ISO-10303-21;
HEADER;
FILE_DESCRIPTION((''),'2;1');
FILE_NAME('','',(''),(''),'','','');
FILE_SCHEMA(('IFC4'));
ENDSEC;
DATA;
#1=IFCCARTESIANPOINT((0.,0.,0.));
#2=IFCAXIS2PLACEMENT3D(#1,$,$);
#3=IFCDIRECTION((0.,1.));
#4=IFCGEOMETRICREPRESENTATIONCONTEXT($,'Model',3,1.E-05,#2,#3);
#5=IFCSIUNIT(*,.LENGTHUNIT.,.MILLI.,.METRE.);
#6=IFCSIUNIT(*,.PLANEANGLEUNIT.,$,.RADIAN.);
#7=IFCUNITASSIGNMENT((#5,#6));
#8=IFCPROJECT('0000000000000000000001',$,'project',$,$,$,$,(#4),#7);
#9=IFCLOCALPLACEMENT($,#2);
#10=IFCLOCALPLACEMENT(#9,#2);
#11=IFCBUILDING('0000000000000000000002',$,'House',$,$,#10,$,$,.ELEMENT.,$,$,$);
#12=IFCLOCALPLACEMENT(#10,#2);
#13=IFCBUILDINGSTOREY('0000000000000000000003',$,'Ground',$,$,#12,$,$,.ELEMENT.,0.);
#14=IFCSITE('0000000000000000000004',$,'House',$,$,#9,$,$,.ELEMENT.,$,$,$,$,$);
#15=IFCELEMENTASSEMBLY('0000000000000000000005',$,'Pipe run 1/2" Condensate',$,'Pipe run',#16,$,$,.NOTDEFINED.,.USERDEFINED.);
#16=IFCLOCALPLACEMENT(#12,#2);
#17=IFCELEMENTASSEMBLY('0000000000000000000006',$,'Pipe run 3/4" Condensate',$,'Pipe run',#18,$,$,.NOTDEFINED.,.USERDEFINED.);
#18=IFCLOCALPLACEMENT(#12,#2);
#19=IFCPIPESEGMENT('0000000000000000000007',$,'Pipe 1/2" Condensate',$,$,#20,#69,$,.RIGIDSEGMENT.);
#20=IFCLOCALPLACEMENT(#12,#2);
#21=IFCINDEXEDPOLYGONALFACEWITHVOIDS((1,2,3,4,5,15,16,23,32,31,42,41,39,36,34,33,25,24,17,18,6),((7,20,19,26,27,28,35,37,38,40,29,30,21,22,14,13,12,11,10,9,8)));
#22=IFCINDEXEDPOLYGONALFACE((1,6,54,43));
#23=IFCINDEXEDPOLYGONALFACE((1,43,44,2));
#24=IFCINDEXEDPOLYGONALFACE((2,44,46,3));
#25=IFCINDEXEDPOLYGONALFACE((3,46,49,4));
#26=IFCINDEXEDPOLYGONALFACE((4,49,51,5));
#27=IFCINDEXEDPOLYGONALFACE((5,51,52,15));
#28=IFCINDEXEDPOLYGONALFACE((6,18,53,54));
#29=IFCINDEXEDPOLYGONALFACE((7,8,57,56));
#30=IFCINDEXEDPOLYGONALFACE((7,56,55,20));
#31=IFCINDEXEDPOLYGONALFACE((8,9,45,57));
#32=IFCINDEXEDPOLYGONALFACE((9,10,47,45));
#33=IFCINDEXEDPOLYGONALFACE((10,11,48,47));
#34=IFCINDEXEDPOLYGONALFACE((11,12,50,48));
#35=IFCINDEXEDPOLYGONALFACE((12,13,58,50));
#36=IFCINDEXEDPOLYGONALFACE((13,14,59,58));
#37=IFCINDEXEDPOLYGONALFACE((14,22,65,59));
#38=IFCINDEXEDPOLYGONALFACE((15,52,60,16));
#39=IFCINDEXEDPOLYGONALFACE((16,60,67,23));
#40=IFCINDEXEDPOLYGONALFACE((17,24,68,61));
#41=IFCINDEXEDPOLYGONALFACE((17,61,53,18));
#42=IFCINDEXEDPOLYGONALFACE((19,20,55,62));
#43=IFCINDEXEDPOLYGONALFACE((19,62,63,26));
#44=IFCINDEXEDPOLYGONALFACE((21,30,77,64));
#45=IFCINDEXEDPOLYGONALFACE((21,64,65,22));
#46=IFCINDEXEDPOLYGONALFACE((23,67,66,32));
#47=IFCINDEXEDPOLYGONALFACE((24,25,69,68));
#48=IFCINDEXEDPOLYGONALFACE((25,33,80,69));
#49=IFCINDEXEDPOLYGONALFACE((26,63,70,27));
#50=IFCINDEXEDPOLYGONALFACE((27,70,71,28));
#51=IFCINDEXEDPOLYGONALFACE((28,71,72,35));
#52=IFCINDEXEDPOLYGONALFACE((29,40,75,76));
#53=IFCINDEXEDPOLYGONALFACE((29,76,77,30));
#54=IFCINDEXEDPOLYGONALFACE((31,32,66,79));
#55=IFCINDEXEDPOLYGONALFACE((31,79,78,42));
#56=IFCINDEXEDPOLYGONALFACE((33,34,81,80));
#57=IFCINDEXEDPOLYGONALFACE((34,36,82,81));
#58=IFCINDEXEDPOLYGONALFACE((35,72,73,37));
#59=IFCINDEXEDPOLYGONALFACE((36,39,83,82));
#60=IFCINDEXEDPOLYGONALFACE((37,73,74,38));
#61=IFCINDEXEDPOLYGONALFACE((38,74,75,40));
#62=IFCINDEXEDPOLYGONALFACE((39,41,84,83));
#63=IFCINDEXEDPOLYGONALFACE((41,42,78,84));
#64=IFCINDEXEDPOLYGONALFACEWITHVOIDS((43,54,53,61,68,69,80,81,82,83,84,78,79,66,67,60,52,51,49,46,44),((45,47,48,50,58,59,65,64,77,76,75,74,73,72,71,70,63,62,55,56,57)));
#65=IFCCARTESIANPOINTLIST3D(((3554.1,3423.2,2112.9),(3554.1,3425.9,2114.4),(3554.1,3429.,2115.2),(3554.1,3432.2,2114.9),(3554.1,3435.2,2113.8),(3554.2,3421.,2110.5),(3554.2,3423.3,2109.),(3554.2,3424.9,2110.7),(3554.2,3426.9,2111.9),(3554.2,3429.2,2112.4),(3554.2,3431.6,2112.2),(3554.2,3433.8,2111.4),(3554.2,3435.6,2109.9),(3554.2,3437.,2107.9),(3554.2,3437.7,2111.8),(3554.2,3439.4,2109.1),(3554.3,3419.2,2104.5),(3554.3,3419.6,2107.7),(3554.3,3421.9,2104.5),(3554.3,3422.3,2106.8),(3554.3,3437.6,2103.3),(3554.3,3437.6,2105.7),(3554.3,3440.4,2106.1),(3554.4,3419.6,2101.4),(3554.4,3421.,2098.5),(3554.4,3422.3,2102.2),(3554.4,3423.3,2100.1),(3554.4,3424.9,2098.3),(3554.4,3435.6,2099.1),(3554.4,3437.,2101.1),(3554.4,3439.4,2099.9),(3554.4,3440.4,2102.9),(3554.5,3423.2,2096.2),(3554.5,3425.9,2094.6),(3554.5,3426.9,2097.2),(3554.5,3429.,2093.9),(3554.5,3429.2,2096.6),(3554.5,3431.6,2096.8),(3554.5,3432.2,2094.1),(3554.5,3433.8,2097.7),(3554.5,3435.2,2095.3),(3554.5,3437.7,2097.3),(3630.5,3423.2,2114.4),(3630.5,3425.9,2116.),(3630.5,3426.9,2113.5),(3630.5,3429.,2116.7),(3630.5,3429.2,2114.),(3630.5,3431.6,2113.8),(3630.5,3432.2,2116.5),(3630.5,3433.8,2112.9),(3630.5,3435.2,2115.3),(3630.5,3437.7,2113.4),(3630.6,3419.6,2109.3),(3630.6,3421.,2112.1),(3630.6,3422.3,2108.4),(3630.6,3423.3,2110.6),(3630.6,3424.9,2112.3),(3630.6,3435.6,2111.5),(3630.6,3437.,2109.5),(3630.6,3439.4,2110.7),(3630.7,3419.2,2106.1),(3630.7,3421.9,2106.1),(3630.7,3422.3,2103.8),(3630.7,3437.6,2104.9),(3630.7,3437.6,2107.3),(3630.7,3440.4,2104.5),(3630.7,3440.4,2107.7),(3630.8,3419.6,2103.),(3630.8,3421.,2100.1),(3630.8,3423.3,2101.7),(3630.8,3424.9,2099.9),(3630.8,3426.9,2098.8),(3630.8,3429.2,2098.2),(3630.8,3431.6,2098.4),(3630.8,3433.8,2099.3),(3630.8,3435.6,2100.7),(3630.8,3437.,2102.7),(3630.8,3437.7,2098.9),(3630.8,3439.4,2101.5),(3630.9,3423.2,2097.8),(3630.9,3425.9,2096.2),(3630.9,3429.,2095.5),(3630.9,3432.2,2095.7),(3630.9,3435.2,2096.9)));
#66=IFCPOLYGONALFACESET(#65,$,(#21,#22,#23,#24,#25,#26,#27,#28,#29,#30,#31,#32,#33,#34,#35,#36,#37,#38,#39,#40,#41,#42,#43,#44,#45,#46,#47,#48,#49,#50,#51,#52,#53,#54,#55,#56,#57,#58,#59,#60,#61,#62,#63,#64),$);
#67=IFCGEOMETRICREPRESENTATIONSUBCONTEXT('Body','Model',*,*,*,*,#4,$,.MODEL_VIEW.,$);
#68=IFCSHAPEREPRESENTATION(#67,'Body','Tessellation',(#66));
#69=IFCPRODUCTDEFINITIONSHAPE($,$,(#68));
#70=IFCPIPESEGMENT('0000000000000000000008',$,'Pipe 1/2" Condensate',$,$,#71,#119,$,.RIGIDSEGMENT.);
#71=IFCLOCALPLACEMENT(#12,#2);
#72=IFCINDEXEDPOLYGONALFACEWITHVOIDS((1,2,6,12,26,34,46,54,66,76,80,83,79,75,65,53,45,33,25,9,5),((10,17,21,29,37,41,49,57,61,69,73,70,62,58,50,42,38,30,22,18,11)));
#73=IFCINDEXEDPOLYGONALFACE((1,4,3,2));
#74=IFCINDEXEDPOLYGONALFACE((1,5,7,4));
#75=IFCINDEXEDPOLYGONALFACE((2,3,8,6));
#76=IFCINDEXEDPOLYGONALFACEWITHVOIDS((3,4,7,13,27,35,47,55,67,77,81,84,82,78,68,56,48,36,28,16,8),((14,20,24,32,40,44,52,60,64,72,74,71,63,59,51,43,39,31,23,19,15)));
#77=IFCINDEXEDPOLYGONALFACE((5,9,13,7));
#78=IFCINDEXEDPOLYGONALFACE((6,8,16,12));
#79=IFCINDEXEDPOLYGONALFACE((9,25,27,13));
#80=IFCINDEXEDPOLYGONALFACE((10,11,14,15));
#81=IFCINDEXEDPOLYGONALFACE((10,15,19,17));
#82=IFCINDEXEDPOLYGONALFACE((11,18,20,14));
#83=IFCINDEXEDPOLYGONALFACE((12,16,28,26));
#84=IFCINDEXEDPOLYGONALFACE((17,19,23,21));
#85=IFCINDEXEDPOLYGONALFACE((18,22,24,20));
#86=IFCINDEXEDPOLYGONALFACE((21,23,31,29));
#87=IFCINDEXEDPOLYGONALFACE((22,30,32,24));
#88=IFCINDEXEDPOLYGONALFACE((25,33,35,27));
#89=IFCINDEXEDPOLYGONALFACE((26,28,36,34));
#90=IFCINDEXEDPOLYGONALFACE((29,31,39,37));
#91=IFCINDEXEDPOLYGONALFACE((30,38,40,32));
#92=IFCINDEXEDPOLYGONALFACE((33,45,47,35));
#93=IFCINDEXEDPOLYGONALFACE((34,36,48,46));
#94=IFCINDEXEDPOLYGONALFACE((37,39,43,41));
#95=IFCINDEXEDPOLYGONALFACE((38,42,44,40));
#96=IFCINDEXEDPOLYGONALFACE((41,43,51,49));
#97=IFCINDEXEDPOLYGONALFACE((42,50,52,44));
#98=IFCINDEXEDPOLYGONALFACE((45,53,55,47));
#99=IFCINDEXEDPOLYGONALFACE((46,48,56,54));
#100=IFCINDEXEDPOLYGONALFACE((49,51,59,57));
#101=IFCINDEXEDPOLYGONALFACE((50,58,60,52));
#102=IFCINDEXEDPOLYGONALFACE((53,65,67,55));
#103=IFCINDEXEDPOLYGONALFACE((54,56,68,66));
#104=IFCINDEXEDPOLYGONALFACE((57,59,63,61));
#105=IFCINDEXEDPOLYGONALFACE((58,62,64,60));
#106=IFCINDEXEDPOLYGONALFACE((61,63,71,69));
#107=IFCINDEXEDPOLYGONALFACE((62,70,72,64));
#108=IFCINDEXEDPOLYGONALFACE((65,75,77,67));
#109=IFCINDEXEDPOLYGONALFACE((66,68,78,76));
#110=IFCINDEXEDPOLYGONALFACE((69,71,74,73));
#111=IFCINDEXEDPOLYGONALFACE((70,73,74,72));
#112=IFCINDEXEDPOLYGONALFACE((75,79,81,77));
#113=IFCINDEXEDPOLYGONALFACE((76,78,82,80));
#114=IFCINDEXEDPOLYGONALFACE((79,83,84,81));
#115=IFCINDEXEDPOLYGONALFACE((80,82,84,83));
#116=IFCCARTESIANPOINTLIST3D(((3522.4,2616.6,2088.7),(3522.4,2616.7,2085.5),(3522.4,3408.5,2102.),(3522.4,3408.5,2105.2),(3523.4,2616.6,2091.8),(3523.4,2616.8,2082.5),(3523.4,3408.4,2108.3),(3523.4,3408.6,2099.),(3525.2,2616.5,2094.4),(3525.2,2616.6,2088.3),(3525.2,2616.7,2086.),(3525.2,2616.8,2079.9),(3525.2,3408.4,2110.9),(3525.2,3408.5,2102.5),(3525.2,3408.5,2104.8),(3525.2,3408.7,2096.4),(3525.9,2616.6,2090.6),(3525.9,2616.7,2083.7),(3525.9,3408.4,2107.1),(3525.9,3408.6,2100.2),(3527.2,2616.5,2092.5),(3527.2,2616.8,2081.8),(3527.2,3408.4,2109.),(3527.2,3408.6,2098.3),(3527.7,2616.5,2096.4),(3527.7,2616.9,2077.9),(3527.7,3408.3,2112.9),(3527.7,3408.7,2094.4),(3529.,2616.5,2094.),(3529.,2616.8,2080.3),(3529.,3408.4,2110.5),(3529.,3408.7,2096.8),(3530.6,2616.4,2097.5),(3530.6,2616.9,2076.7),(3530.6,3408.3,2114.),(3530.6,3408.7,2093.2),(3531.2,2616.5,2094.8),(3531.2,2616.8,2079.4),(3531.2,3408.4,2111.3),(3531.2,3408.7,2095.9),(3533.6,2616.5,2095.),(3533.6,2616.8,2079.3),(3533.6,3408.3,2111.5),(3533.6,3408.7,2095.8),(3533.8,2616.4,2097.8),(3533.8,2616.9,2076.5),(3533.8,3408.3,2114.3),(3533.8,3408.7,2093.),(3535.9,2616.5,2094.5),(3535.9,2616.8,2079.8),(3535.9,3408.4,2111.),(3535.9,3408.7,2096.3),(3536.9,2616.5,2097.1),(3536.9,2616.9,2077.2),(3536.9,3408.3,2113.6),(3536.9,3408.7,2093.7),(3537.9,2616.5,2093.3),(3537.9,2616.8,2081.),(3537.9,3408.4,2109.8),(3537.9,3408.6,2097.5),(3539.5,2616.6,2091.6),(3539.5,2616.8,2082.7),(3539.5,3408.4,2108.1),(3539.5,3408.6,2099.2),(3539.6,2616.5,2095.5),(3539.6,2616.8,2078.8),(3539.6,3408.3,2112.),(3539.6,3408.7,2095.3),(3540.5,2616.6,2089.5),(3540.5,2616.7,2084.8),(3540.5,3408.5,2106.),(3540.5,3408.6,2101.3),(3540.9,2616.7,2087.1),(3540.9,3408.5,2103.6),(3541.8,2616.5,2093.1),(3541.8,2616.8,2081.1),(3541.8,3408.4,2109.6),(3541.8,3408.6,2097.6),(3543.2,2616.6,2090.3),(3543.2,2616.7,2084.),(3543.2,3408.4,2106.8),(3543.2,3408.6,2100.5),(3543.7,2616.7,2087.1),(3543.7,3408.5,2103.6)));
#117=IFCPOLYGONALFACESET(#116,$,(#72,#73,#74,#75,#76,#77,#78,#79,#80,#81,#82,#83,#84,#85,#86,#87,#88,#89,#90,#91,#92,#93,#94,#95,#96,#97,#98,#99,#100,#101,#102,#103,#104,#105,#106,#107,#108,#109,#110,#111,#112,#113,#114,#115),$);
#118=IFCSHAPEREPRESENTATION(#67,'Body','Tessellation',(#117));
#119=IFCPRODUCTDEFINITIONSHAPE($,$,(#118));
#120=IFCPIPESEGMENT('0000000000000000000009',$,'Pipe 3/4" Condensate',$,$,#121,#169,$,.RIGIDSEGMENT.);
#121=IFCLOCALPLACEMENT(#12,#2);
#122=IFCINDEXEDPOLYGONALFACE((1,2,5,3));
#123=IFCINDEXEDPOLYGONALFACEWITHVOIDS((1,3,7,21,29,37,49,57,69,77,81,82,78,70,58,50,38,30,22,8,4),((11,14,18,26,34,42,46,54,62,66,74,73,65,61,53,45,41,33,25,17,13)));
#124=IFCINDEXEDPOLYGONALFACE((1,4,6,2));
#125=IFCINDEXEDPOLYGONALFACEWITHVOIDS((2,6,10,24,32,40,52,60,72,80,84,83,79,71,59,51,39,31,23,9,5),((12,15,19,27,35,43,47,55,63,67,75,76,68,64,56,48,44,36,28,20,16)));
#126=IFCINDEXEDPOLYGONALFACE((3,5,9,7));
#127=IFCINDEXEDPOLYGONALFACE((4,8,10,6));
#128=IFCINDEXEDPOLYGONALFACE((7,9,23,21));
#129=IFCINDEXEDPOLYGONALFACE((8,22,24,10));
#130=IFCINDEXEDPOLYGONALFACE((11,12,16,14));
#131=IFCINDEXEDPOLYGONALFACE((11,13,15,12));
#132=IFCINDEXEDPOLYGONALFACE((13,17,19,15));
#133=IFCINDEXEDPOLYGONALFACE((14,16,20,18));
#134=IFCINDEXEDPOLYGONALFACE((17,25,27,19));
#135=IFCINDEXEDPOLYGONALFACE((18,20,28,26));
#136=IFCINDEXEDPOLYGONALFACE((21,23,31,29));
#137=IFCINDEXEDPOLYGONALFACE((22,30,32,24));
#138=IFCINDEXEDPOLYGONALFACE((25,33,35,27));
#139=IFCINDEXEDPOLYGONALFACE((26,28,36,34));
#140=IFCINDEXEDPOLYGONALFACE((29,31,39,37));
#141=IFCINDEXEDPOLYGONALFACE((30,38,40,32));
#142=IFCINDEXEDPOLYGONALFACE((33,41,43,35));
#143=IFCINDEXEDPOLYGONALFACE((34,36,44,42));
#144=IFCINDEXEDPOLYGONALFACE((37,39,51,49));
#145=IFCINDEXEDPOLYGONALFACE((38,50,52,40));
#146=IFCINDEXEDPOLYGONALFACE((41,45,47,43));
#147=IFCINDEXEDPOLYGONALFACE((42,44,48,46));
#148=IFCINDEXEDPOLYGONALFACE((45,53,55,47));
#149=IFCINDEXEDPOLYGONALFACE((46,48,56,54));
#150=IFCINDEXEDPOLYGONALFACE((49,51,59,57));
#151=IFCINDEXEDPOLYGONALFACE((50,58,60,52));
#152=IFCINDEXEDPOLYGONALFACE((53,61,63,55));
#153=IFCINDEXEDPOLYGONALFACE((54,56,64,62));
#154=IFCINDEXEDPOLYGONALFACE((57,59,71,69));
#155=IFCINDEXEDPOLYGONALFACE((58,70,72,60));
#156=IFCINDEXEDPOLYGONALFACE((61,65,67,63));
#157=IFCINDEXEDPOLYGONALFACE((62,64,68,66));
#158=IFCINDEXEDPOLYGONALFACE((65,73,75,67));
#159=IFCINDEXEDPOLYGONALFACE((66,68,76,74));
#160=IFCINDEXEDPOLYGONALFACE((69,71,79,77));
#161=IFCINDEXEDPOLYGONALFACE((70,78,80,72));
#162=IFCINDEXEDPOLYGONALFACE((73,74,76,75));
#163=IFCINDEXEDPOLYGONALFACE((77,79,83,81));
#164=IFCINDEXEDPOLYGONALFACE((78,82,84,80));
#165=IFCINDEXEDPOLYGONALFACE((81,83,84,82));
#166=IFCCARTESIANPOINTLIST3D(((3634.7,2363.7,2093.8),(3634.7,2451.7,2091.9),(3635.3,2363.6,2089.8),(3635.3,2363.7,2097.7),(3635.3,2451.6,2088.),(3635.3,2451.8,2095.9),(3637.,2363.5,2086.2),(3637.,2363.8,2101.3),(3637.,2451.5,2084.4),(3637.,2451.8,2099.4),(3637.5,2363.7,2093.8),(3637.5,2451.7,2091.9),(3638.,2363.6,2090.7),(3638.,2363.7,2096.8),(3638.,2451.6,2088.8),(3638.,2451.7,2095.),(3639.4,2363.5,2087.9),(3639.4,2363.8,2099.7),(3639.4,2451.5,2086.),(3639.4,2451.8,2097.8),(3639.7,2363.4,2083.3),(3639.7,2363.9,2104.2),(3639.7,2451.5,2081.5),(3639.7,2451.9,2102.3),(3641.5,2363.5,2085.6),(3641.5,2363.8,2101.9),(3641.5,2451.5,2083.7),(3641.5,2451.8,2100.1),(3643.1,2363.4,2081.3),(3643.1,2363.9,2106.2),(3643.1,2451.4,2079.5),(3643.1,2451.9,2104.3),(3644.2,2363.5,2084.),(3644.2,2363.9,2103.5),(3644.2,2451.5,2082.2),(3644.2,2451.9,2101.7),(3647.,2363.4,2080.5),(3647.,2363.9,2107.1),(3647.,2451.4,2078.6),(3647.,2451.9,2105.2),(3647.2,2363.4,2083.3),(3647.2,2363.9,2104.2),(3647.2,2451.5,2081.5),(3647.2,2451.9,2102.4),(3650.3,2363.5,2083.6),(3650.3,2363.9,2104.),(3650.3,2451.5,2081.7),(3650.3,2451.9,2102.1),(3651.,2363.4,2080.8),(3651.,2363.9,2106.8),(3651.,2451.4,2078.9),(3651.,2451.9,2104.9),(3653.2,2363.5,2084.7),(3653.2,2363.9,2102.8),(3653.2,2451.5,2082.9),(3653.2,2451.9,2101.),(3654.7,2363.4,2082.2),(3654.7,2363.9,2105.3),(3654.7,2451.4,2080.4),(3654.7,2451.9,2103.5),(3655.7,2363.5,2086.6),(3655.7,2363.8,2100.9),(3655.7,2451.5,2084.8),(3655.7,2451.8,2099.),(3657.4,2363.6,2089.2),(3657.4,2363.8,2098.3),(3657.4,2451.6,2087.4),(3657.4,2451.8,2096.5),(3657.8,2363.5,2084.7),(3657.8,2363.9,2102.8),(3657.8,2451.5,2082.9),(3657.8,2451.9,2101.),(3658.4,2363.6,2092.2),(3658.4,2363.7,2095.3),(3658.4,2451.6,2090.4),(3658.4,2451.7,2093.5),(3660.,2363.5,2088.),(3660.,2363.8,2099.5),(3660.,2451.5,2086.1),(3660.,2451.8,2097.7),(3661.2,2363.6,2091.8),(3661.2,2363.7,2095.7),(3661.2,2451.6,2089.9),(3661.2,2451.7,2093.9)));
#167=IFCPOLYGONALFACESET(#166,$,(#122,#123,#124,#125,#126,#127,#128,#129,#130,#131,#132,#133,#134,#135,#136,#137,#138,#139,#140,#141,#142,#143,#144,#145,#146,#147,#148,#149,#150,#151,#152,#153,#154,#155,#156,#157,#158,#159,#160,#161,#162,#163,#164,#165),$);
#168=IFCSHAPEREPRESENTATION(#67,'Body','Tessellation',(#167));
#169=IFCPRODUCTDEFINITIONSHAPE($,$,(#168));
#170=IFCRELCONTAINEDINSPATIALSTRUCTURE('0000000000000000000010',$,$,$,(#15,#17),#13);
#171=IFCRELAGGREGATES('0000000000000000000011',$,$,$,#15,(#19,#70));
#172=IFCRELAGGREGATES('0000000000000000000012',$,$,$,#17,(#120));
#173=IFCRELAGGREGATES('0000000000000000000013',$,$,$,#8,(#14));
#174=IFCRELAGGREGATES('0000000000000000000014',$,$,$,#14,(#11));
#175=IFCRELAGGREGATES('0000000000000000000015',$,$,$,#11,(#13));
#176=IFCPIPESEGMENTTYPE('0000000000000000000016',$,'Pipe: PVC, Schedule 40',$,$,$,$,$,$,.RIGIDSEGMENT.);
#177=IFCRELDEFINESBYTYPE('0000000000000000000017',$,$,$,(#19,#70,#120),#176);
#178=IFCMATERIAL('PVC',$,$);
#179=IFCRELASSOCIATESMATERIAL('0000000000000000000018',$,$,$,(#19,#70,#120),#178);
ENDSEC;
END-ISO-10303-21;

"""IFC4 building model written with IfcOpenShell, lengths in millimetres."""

from ifc_helpers import new_model, si_unit, direction, frame, origin, origin_with_axes, origin_2d, place, context, subcontext, project, spatial, hollow_circle, extrude, material, type_object, element, aggregate, save


model = new_model("IFC4")

# Units and contexts
model_context = context("Model", 3, precision=1e-05, world=origin(), true_north=direction((0.0, 1.0)))
body_context = subcontext(model_context, "Body", "Model", "MODEL_VIEW")
ifc_project = project(units=[si_unit("LENGTHUNIT", "METRE", prefix="MILLI"), si_unit("PLANEANGLEUNIT", "RADIAN")], contexts=[model_context])

# Site, building, storey
site_placement = place(None, origin())
site = spatial("IfcSite", under=ifc_project, at=site_placement, Name="House", CompositionType="ELEMENT")
building_placement = place(site_placement, origin())
building = spatial("IfcBuilding", under=site, at=building_placement, Name="House", CompositionType="ELEMENT")
storey_placement = place(building_placement, origin())
storey = spatial("IfcBuildingStorey", under=building, at=storey_placement, Name="Ground", CompositionType="ELEMENT", Elevation=0.0)

# Element assemblies
ifc_material_1 = material(Name="PVC")
assembly_1_placement = place(storey_placement, origin_with_axes())
assembly_1 = element("IfcElementAssembly", 1, at=assembly_1_placement, inside=storey, Name="Pipe run 1/2\" Condensate", ObjectType="Pipe run", AssemblyPlace="NOTDEFINED", PredefinedType="USERDEFINED")
assembly_2_placement = place(storey_placement, origin_with_axes())
assembly_2 = element("IfcElementAssembly", 2, at=assembly_2_placement, inside=storey, Name="Pipe run 3/4\" Condensate", ObjectType="Pipe run", AssemblyPlace="NOTDEFINED", PredefinedType="USERDEFINED")

# Pipe segments
pipe_segment_type_1 = type_object("IfcPipeSegmentType", Name="Pipe: PVC, Schedule 40", PredefinedType="RIGIDSEGMENT")
pipe_segment_1_placement = place(storey_placement, origin_with_axes())
pipe_segment_1 = element("IfcPipeSegment", 3, at=pipe_segment_1_placement, type_object=pipe_segment_type_1, material=ifc_material_1, Name="Pipe 1/2\" Condensate", PredefinedType="RIGIDSEGMENT", context=body_context, shape_type="SweptSolid", body=[
    extrude(hollow_circle(Radius=10.7, WallThickness=2.8, at=origin_2d()), frame((3630.7, 3429.8, 2106.1), z_axis=(-0.999783, 0.0, -0.020829), x_axis=(0.0, -1.0, 0.0)), (0.0, 0.0, 1.0), 76.4),
])
pipe_segment_2_placement = place(storey_placement, origin_with_axes())
pipe_segment_2 = element("IfcPipeSegment", 4, at=pipe_segment_2_placement, type_object=pipe_segment_type_1, material=ifc_material_1, Name="Pipe 1/2\" Condensate", PredefinedType="RIGIDSEGMENT", context=body_context, shape_type="SweptSolid", body=[
    extrude(hollow_circle(Radius=10.7, WallThickness=2.8, at=origin_2d()), frame((3533.0, 3408.5, 2103.6), z_axis=(0.0, -0.999783, -0.020829), x_axis=(1.0, 0.0, 0.0)), (0.0, 0.0, 1.0), 792.0),
])
aggregate(assembly_1, [pipe_segment_1, pipe_segment_2])
pipe_segment_3_placement = place(storey_placement, origin_with_axes())
pipe_segment_3 = element("IfcPipeSegment", 5, at=pipe_segment_3_placement, type_object=pipe_segment_type_1, material=ifc_material_1, Name="Pipe 3/4\" Condensate", PredefinedType="RIGIDSEGMENT", context=body_context, shape_type="SweptSolid", body=[
    extrude(hollow_circle(Radius=13.3, WallThickness=2.9, at=origin_2d()), frame((3648.0, 2363.7, 2093.8), z_axis=(0.0, 0.999783, -0.020829), x_axis=(-1.0, 0.0, 0.0)), (0.0, 0.0, 1.0), 88.0),
])
aggregate(assembly_2, [pipe_segment_3])

save(model, "model.ifc")
